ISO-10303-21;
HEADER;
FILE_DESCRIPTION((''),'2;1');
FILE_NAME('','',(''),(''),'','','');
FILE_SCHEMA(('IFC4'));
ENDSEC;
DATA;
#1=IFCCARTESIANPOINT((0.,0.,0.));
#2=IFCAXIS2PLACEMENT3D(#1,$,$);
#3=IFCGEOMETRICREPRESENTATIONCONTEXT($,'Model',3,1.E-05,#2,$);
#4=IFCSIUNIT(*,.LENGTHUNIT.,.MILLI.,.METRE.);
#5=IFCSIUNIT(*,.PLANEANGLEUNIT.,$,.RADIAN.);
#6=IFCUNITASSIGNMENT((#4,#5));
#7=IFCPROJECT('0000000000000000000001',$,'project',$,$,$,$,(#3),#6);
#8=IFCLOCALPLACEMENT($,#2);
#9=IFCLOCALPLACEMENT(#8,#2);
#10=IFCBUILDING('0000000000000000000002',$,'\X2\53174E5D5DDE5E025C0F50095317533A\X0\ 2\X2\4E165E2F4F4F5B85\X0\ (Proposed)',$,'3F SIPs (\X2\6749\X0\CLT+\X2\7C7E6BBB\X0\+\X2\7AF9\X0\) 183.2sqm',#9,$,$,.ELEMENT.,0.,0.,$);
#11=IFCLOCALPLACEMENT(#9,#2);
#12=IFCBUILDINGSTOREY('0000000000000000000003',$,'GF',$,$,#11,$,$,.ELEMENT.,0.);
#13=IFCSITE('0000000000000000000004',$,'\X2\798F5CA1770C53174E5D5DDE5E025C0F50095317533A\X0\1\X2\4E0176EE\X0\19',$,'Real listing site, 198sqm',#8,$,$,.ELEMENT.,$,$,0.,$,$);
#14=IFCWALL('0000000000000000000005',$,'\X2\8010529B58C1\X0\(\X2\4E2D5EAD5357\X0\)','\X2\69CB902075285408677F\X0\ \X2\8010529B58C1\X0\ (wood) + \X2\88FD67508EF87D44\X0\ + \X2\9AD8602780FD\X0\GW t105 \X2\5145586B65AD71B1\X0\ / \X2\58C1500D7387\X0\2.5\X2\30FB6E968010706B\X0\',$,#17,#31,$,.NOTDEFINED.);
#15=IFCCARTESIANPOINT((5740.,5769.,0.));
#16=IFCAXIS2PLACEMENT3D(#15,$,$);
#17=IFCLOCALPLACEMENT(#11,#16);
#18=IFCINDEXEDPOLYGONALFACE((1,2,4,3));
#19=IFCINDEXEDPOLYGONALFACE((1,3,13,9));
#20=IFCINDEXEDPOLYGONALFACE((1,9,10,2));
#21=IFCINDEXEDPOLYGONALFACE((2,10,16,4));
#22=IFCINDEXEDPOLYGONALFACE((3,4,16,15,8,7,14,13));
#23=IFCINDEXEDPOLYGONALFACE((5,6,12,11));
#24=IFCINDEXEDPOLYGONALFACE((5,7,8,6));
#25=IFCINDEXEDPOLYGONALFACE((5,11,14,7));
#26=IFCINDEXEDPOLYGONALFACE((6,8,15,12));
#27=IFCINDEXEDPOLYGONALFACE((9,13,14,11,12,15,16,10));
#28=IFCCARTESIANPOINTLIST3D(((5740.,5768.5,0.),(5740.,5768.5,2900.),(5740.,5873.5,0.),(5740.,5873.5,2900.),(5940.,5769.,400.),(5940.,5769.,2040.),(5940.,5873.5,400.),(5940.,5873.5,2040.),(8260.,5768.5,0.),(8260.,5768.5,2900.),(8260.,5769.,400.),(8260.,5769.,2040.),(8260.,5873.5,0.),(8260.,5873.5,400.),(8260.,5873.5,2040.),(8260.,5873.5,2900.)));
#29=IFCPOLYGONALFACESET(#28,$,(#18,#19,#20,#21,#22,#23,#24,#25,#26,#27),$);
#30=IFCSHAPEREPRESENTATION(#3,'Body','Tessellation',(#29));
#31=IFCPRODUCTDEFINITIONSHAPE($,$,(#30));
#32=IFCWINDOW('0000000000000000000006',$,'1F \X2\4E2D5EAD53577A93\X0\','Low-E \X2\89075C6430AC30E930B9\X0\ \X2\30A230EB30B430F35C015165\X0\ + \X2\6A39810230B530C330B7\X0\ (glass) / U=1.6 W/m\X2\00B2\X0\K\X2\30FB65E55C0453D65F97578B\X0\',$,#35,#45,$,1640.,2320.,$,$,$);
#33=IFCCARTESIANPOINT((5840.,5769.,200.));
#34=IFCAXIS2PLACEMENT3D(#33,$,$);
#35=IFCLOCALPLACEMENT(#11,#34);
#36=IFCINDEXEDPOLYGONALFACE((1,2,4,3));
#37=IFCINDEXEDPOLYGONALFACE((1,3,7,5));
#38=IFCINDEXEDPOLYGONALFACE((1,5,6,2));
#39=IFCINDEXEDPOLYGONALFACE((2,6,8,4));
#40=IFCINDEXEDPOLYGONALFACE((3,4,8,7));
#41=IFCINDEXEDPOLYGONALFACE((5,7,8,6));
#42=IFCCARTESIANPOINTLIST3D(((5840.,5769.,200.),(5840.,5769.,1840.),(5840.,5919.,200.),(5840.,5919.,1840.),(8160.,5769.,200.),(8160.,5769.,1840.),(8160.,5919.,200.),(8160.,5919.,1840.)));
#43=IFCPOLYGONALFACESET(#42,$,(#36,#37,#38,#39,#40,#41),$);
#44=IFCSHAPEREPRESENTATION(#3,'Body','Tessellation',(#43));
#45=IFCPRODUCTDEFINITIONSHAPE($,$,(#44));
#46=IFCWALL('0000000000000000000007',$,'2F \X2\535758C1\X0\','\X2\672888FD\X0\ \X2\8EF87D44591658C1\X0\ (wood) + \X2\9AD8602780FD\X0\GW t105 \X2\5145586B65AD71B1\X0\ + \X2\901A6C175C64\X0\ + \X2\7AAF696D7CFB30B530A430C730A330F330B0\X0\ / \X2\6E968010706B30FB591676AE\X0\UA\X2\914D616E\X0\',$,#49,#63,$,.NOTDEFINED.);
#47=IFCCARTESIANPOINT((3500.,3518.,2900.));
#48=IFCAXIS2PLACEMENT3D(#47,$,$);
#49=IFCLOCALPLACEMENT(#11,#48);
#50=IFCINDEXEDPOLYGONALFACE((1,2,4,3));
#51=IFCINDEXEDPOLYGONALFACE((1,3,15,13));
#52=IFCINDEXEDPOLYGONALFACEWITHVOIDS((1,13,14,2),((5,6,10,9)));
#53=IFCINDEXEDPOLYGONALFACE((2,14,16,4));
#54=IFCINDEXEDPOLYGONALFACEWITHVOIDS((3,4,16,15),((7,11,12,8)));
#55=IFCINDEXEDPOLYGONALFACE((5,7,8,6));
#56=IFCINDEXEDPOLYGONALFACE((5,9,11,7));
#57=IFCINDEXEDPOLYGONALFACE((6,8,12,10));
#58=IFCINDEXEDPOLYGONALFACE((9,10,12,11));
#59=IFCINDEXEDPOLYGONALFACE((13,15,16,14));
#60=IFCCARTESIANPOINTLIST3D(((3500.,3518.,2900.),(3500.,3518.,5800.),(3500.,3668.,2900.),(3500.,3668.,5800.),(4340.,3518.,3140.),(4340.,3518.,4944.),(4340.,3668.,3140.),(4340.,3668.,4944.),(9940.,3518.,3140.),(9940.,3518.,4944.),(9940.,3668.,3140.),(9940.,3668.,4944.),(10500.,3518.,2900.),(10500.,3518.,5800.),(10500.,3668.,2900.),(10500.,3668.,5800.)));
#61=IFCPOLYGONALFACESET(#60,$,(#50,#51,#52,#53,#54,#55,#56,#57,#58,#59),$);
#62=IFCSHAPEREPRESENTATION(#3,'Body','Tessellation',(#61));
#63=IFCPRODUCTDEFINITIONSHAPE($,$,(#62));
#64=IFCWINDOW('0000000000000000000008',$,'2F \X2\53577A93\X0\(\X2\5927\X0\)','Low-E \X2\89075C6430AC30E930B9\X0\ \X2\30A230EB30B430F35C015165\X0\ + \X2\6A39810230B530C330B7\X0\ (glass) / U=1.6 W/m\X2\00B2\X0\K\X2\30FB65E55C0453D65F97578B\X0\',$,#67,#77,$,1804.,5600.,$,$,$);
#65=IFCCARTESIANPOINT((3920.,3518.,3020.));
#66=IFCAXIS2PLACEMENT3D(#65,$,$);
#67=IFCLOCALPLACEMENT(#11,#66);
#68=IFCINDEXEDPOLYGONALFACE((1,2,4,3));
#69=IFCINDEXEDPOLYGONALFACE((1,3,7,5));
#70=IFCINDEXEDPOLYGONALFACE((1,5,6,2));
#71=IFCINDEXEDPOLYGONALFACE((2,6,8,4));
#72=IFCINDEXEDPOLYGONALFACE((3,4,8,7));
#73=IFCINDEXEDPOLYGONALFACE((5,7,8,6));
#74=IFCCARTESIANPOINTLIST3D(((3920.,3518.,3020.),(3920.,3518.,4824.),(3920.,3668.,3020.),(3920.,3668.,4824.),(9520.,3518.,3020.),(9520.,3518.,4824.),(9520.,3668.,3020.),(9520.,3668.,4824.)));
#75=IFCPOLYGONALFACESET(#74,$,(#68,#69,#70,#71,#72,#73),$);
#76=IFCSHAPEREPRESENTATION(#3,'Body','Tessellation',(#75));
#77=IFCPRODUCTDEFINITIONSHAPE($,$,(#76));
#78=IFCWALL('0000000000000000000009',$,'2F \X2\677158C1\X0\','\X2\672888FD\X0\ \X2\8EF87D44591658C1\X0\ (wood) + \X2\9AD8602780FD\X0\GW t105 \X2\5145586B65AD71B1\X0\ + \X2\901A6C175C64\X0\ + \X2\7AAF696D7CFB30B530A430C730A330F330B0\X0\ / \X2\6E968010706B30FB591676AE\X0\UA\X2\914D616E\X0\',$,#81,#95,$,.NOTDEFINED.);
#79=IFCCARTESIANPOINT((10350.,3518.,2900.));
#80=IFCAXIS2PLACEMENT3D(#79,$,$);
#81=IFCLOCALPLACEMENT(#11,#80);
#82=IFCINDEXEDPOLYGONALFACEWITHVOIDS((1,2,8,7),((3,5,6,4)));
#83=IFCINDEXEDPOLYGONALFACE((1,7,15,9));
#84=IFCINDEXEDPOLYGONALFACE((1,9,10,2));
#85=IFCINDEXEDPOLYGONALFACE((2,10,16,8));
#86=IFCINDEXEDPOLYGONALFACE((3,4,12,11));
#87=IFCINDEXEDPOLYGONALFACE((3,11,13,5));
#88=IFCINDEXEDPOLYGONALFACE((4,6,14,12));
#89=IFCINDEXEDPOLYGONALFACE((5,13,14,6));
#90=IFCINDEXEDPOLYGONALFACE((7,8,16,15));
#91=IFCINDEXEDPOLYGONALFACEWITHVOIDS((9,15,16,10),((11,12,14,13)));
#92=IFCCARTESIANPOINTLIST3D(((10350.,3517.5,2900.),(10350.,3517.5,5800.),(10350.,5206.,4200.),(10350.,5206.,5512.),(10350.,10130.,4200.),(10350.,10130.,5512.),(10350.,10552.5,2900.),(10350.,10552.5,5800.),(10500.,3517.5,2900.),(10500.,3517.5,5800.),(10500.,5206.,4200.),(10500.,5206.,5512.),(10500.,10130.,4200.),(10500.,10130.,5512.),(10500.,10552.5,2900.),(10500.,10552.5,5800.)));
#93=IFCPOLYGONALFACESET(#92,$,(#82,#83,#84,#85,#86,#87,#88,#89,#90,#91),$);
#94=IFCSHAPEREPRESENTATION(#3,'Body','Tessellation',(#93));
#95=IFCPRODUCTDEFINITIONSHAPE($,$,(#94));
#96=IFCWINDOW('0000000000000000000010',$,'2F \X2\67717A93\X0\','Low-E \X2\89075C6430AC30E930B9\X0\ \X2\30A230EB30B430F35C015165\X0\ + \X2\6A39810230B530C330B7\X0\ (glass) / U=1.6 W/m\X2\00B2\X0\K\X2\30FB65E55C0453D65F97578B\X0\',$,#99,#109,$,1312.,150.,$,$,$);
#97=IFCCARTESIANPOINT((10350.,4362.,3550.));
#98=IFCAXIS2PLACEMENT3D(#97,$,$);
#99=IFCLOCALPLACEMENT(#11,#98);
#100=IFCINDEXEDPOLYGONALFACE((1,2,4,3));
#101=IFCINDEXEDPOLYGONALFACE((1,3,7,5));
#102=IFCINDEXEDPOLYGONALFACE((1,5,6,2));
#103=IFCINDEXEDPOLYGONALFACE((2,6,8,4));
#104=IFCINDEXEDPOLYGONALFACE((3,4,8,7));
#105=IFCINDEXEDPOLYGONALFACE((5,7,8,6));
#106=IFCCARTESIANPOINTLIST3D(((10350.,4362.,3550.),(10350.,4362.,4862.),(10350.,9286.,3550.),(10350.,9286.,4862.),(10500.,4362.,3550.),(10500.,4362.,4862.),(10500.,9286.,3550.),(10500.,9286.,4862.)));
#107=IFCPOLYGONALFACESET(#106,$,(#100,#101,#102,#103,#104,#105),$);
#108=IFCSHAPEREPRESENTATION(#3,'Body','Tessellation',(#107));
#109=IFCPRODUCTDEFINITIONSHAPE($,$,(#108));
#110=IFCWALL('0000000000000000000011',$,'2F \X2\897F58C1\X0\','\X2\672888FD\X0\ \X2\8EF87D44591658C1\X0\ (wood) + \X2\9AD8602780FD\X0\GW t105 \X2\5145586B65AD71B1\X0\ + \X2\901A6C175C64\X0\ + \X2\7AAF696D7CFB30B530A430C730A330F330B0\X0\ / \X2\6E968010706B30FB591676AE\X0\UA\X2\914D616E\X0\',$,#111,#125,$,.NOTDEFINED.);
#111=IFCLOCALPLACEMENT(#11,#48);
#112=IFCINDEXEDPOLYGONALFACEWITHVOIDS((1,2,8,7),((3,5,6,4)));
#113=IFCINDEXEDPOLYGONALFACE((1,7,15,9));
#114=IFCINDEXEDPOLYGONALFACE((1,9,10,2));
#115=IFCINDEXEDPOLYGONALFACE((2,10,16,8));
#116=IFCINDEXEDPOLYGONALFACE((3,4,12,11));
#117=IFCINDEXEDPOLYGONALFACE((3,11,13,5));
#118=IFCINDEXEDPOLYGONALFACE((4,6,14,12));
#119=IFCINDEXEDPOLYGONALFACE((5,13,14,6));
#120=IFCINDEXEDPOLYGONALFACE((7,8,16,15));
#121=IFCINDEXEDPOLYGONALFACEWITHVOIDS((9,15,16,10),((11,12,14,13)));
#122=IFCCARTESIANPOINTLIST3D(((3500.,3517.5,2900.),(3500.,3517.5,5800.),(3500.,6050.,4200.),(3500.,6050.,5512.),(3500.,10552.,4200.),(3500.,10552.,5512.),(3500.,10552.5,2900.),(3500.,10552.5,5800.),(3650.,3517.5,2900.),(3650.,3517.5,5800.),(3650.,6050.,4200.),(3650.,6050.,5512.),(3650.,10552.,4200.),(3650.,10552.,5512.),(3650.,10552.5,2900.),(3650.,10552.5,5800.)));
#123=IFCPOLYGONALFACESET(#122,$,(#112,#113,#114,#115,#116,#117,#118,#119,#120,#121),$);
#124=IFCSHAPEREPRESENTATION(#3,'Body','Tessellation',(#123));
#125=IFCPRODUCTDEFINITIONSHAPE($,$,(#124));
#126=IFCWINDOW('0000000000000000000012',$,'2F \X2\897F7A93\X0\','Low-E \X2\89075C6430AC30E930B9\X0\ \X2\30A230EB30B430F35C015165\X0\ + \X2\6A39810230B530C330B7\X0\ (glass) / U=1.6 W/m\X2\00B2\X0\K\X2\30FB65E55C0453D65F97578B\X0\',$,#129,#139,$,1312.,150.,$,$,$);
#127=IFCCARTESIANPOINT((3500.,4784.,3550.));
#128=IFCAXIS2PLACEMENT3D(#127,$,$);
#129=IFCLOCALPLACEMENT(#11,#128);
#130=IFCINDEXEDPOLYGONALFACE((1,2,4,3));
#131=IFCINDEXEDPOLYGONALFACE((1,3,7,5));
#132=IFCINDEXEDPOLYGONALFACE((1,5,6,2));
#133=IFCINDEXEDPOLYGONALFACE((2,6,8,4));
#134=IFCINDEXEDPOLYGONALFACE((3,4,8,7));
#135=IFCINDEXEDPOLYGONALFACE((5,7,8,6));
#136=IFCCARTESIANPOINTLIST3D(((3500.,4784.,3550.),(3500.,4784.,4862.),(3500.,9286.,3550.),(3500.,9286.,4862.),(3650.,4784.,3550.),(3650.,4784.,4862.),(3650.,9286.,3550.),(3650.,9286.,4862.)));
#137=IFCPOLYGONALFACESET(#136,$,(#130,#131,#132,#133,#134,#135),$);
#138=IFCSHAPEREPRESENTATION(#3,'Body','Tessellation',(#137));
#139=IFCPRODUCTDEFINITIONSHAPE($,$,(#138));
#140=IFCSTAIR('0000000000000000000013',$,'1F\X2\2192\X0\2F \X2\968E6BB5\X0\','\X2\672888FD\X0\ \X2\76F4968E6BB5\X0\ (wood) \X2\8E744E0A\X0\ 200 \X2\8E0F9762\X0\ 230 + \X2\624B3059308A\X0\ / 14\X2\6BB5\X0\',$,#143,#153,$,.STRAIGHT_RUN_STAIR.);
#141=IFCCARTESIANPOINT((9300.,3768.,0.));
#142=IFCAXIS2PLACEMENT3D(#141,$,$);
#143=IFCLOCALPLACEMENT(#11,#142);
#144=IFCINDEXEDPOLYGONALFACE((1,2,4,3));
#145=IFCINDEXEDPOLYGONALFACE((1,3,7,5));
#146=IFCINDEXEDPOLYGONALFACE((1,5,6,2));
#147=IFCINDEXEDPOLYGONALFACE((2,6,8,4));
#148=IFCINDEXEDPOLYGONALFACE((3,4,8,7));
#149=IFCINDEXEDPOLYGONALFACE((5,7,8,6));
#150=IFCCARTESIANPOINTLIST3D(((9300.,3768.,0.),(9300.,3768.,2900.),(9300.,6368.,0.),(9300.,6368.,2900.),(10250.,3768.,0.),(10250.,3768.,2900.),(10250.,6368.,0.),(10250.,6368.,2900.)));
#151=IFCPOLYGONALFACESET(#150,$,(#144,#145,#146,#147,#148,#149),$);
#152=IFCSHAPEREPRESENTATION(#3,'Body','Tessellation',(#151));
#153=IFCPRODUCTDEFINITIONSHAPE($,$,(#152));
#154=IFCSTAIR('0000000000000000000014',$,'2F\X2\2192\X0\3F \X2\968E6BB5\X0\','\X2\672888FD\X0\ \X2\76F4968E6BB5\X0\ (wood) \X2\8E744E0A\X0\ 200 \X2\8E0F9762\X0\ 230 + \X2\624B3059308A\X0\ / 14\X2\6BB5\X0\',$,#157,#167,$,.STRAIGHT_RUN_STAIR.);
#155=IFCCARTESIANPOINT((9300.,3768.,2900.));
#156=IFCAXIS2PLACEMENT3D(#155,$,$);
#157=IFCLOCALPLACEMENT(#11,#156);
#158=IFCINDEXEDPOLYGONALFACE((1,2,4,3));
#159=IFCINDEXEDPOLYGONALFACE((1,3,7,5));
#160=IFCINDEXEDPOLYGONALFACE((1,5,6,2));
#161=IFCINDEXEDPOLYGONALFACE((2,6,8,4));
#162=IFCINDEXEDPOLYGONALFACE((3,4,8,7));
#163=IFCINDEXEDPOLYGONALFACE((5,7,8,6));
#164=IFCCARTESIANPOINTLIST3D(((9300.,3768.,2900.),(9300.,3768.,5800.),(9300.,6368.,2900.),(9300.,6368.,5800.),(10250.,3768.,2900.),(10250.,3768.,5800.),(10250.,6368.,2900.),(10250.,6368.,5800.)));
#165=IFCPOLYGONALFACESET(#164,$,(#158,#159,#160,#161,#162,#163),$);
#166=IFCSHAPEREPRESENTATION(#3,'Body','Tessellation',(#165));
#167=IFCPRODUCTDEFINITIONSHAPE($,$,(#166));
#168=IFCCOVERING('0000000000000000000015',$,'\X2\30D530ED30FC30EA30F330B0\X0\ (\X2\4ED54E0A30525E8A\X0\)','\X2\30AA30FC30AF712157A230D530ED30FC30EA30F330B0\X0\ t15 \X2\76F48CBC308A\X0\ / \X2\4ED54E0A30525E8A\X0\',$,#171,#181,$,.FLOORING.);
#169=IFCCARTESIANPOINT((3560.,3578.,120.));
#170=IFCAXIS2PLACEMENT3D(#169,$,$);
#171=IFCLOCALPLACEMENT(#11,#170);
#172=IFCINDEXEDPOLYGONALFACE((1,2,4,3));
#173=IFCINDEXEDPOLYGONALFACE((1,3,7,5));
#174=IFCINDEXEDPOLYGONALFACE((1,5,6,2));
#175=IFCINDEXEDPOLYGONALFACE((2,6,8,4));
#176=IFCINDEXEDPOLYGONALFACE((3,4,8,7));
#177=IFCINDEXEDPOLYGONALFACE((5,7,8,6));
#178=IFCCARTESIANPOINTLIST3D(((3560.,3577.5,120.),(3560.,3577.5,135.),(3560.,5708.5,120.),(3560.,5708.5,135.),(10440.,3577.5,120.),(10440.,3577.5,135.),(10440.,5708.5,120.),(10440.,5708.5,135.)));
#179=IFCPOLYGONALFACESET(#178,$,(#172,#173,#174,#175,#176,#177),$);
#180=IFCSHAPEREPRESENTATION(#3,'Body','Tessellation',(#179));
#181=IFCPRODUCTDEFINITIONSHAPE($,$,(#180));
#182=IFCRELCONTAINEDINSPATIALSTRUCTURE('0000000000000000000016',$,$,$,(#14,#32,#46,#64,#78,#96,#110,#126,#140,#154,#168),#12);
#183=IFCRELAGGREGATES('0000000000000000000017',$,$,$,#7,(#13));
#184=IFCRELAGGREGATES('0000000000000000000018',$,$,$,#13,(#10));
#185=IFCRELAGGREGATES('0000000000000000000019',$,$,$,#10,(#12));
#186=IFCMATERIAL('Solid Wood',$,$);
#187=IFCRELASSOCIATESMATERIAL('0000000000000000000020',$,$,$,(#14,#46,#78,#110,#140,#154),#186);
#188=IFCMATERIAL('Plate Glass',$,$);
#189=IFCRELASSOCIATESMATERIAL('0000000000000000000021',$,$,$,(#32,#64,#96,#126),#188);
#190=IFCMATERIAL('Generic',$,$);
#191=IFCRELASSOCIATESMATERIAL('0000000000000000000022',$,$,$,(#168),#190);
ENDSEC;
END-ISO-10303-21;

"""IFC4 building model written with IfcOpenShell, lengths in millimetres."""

from ifc_helpers import new_model, si_unit, frame, frame_2d, origin, place, context, project, spatial, rectangle, extrude, material, element, fill, save


model = new_model("IFC4")

# Units and contexts
model_context = context("Model", 3, precision=1e-05, world=origin())
ifc_project = project(units=[si_unit("LENGTHUNIT", "METRE", prefix="MILLI"), si_unit("PLANEANGLEUNIT", "RADIAN")], contexts=[model_context])

# Site, building, storey
site_placement = place(None, origin())
site = spatial("IfcSite", under=ifc_project, at=site_placement, Name="福岡県北九州市小倉北区1丁目19", ObjectType="Real listing site, 198sqm", CompositionType="ELEMENT", RefElevation=0.0)
building_placement = place(site_placement, origin())
building = spatial("IfcBuilding", under=site, at=building_placement, Name="北九州市小倉北区 2世帯住宅 (Proposed)", ObjectType="3F SIPs (杉CLT+籾殻+竹) 183.2sqm", CompositionType="ELEMENT", ElevationOfRefHeight=0.0, ElevationOfTerrain=0.0)
storey_placement = place(building_placement, origin())
storey = spatial("IfcBuildingStorey", under=building, at=storey_placement, Name="GF", CompositionType="ELEMENT", Elevation=0.0)

# Shared definitions
ifc_material_1 = material(Name="Solid Wood")

# Shared definitions
ifc_material_2 = material(Name="Plate Glass")

# Walls, openings, windows
wall_1_placement = place(storey_placement, frame((5740.0, 5769.0, 0.0)))
wall_1 = element("IfcWall", 1, at=wall_1_placement, inside=storey, material=ifc_material_1, Name="耐力壁(中庭南)", Description="構造用合板 耐力壁 (wood) + 製材軸組 + 高性能GW t105 充填断熱 / 壁倍率2.5・準耐火", PredefinedType="NOTDEFINED", context=model_context, shape_type="SweptSolid", body=[
    extrude(rectangle(XDim=2520.0, YDim=105.0, at=frame_2d((1260.0, 52.0))), frame((5740.0, 5769.0, 0.0)), (0.0, 0.0, 1.0), 2900.0),
])
opening_1_placement = place(storey_placement, frame((5840.0, 5769.0, 200.0)))
opening_1 = element("IfcOpeningElement", 2, at=opening_1_placement, cuts=wall_1, PredefinedType="NOTDEFINED", context=model_context, shape_type="SweptSolid", body=[
    extrude(rectangle(XDim=2320.0, YDim=150.0, at=frame_2d((1160.0, 75.0))), frame((5840.0, 5769.0, 200.0)), (0.0, 0.0, 1.0), 1640.0),
])
window_1_placement = place(storey_placement, frame((5840.0, 5769.0, 200.0)))
window_1 = element("IfcWindow", 3, at=window_1_placement, inside=storey, material=ifc_material_2, Name="1F 中庭南窓", Description="Low-E 複層ガラス アルゴン封入 + 樹脂サッシ (glass) / U=1.6 W/m²K・日射取得型", OverallHeight=1640.0, OverallWidth=2320.0, context=model_context, shape_type="SweptSolid", body=[
    extrude(rectangle(XDim=2320.0, YDim=150.0, at=frame_2d((1160.0, 75.0))), frame((5840.0, 5769.0, 200.0)), (0.0, 0.0, 1.0), 1640.0),
])
fill(opening_1, window_1)
wall_2_placement = place(storey_placement, frame((3500.0, 3518.0, 2900.0)))
wall_2 = element("IfcWall", 4, at=wall_2_placement, inside=storey, material=ifc_material_1, Name="2F 南壁", Description="木製 軸組外壁 (wood) + 高性能GW t105 充填断熱 + 通気層 + 窯業系サイディング / 準耐火・外皮UA配慮", PredefinedType="NOTDEFINED", context=model_context, shape_type="SweptSolid", body=[
    extrude(rectangle(XDim=7000.0, YDim=150.0, at=frame_2d((3500.0, 75.0))), frame((3500.0, 3518.0, 2900.0)), (0.0, 0.0, 1.0), 2900.0),
])
opening_2_placement = place(storey_placement, frame((3920.0, 3518.0, 3020.0)))
opening_2 = element("IfcOpeningElement", 5, at=opening_2_placement, cuts=wall_2, PredefinedType="NOTDEFINED", context=model_context, shape_type="SweptSolid", body=[
    extrude(rectangle(XDim=5600.0, YDim=150.0, at=frame_2d((2800.0, 75.0))), frame((3920.0, 3518.0, 3020.0)), (0.0, 0.0, 1.0), 1804.0),
])
window_2_placement = place(storey_placement, frame((3920.0, 3518.0, 3020.0)))
window_2 = element("IfcWindow", 6, at=window_2_placement, inside=storey, material=ifc_material_2, Name="2F 南窓(大)", Description="Low-E 複層ガラス アルゴン封入 + 樹脂サッシ (glass) / U=1.6 W/m²K・日射取得型", OverallHeight=1804.0, OverallWidth=5600.0, context=model_context, shape_type="SweptSolid", body=[
    extrude(rectangle(XDim=5600.0, YDim=150.0, at=frame_2d((2800.0, 75.0))), frame((3920.0, 3518.0, 3020.0)), (0.0, 0.0, 1.0), 1804.0),
])
fill(opening_2, window_2)
wall_3_placement = place(storey_placement, frame((10350.0, 3518.0, 2900.0)))
wall_3 = element("IfcWall", 7, at=wall_3_placement, inside=storey, material=ifc_material_1, Name="2F 東壁", Description="木製 軸組外壁 (wood) + 高性能GW t105 充填断熱 + 通気層 + 窯業系サイディング / 準耐火・外皮UA配慮", PredefinedType="NOTDEFINED", context=model_context, shape_type="SweptSolid", body=[
    extrude(rectangle(XDim=150.0, YDim=7035.0, at=frame_2d((75.0, 3517.0))), frame((10350.0, 3518.0, 2900.0)), (0.0, 0.0, 1.0), 2900.0),
])
opening_3_placement = place(storey_placement, frame((10350.0, 4362.0, 3550.0)))
opening_3 = element("IfcOpeningElement", 8, at=opening_3_placement, cuts=wall_3, PredefinedType="NOTDEFINED", context=model_context, shape_type="SweptSolid", body=[
    extrude(rectangle(XDim=150.0, YDim=4924.0, at=frame_2d((75.0, 2462.0))), frame((10350.0, 4362.0, 3550.0)), (0.0, 0.0, 1.0), 1312.0),
])
window_3_placement = place(storey_placement, frame((10350.0, 4362.0, 3550.0)))
window_3 = element("IfcWindow", 9, at=window_3_placement, inside=storey, material=ifc_material_2, Name="2F 東窓", Description="Low-E 複層ガラス アルゴン封入 + 樹脂サッシ (glass) / U=1.6 W/m²K・日射取得型", OverallHeight=1312.0, OverallWidth=150.0, context=model_context, shape_type="SweptSolid", body=[
    extrude(rectangle(XDim=150.0, YDim=4924.0, at=frame_2d((75.0, 2462.0))), frame((10350.0, 4362.0, 3550.0)), (0.0, 0.0, 1.0), 1312.0),
])
fill(opening_3, window_3)
wall_4_placement = place(storey_placement, frame((3500.0, 3518.0, 2900.0)))
wall_4 = element("IfcWall", 10, at=wall_4_placement, inside=storey, material=ifc_material_1, Name="2F 西壁", Description="木製 軸組外壁 (wood) + 高性能GW t105 充填断熱 + 通気層 + 窯業系サイディング / 準耐火・外皮UA配慮", PredefinedType="NOTDEFINED", context=model_context, shape_type="SweptSolid", body=[
    extrude(rectangle(XDim=150.0, YDim=7035.0, at=frame_2d((75.0, 3517.0))), frame((3500.0, 3518.0, 2900.0)), (0.0, 0.0, 1.0), 2900.0),
])
opening_4_placement = place(storey_placement, frame((3500.0, 4784.0, 3550.0)))
opening_4 = element("IfcOpeningElement", 11, at=opening_4_placement, cuts=wall_4, PredefinedType="NOTDEFINED", context=model_context, shape_type="SweptSolid", body=[
    extrude(rectangle(XDim=150.0, YDim=4502.0, at=frame_2d((75.0, 2251.0))), frame((3500.0, 4784.0, 3550.0)), (0.0, 0.0, 1.0), 1312.0),
])
window_4_placement = place(storey_placement, frame((3500.0, 4784.0, 3550.0)))
window_4 = element("IfcWindow", 12, at=window_4_placement, inside=storey, material=ifc_material_2, Name="2F 西窓", Description="Low-E 複層ガラス アルゴン封入 + 樹脂サッシ (glass) / U=1.6 W/m²K・日射取得型", OverallHeight=1312.0, OverallWidth=150.0, context=model_context, shape_type="SweptSolid", body=[
    extrude(rectangle(XDim=150.0, YDim=4502.0, at=frame_2d((75.0, 2251.0))), frame((3500.0, 4784.0, 3550.0)), (0.0, 0.0, 1.0), 1312.0),
])
fill(opening_4, window_4)

# Stairs
stair_1_placement = place(storey_placement, frame((9300.0, 3768.0, 0.0)))
element("IfcStair", 13, at=stair_1_placement, inside=storey, material=ifc_material_1, Name="1F→2F 階段", Description="木製 直階段 (wood) 蹴上 200 踏面 230 + 手すり / 14段", PredefinedType="STRAIGHT_RUN_STAIR", context=model_context, shape_type="SweptSolid", body=[
    extrude(rectangle(XDim=950.0, YDim=2600.0, at=frame_2d((475.0, 1300.0))), frame((9300.0, 3768.0, 0.0)), (0.0, 0.0, 1.0), 2900.0),
])
stair_2_placement = place(storey_placement, frame((9300.0, 3768.0, 2900.0)))
element("IfcStair", 14, at=stair_2_placement, inside=storey, material=ifc_material_1, Name="2F→3F 階段", Description="木製 直階段 (wood) 蹴上 200 踏面 230 + 手すり / 14段", PredefinedType="STRAIGHT_RUN_STAIR", context=model_context, shape_type="SweptSolid", body=[
    extrude(rectangle(XDim=950.0, YDim=2600.0, at=frame_2d((475.0, 1300.0))), frame((9300.0, 3768.0, 2900.0)), (0.0, 0.0, 1.0), 2900.0),
])

# Covering
ifc_material_3 = material(Name="Generic")
covering_placement = place(storey_placement, frame((3560.0, 3578.0, 120.0)))
element("IfcCovering", 15, at=covering_placement, inside=storey, material=ifc_material_3, Name="フローリング (仕上げ床)", Description="オーク無垢フローリング t15 直貼り / 仕上げ床", PredefinedType="FLOORING", context=model_context, shape_type="SweptSolid", body=[
    extrude(rectangle(XDim=6880.0, YDim=2131.0, at=frame_2d((3440.0, 1065.0))), frame((3560.0, 3578.0, 120.0)), (0.0, 0.0, 1.0), 15.0),
])

save(model, "model.ifc")
